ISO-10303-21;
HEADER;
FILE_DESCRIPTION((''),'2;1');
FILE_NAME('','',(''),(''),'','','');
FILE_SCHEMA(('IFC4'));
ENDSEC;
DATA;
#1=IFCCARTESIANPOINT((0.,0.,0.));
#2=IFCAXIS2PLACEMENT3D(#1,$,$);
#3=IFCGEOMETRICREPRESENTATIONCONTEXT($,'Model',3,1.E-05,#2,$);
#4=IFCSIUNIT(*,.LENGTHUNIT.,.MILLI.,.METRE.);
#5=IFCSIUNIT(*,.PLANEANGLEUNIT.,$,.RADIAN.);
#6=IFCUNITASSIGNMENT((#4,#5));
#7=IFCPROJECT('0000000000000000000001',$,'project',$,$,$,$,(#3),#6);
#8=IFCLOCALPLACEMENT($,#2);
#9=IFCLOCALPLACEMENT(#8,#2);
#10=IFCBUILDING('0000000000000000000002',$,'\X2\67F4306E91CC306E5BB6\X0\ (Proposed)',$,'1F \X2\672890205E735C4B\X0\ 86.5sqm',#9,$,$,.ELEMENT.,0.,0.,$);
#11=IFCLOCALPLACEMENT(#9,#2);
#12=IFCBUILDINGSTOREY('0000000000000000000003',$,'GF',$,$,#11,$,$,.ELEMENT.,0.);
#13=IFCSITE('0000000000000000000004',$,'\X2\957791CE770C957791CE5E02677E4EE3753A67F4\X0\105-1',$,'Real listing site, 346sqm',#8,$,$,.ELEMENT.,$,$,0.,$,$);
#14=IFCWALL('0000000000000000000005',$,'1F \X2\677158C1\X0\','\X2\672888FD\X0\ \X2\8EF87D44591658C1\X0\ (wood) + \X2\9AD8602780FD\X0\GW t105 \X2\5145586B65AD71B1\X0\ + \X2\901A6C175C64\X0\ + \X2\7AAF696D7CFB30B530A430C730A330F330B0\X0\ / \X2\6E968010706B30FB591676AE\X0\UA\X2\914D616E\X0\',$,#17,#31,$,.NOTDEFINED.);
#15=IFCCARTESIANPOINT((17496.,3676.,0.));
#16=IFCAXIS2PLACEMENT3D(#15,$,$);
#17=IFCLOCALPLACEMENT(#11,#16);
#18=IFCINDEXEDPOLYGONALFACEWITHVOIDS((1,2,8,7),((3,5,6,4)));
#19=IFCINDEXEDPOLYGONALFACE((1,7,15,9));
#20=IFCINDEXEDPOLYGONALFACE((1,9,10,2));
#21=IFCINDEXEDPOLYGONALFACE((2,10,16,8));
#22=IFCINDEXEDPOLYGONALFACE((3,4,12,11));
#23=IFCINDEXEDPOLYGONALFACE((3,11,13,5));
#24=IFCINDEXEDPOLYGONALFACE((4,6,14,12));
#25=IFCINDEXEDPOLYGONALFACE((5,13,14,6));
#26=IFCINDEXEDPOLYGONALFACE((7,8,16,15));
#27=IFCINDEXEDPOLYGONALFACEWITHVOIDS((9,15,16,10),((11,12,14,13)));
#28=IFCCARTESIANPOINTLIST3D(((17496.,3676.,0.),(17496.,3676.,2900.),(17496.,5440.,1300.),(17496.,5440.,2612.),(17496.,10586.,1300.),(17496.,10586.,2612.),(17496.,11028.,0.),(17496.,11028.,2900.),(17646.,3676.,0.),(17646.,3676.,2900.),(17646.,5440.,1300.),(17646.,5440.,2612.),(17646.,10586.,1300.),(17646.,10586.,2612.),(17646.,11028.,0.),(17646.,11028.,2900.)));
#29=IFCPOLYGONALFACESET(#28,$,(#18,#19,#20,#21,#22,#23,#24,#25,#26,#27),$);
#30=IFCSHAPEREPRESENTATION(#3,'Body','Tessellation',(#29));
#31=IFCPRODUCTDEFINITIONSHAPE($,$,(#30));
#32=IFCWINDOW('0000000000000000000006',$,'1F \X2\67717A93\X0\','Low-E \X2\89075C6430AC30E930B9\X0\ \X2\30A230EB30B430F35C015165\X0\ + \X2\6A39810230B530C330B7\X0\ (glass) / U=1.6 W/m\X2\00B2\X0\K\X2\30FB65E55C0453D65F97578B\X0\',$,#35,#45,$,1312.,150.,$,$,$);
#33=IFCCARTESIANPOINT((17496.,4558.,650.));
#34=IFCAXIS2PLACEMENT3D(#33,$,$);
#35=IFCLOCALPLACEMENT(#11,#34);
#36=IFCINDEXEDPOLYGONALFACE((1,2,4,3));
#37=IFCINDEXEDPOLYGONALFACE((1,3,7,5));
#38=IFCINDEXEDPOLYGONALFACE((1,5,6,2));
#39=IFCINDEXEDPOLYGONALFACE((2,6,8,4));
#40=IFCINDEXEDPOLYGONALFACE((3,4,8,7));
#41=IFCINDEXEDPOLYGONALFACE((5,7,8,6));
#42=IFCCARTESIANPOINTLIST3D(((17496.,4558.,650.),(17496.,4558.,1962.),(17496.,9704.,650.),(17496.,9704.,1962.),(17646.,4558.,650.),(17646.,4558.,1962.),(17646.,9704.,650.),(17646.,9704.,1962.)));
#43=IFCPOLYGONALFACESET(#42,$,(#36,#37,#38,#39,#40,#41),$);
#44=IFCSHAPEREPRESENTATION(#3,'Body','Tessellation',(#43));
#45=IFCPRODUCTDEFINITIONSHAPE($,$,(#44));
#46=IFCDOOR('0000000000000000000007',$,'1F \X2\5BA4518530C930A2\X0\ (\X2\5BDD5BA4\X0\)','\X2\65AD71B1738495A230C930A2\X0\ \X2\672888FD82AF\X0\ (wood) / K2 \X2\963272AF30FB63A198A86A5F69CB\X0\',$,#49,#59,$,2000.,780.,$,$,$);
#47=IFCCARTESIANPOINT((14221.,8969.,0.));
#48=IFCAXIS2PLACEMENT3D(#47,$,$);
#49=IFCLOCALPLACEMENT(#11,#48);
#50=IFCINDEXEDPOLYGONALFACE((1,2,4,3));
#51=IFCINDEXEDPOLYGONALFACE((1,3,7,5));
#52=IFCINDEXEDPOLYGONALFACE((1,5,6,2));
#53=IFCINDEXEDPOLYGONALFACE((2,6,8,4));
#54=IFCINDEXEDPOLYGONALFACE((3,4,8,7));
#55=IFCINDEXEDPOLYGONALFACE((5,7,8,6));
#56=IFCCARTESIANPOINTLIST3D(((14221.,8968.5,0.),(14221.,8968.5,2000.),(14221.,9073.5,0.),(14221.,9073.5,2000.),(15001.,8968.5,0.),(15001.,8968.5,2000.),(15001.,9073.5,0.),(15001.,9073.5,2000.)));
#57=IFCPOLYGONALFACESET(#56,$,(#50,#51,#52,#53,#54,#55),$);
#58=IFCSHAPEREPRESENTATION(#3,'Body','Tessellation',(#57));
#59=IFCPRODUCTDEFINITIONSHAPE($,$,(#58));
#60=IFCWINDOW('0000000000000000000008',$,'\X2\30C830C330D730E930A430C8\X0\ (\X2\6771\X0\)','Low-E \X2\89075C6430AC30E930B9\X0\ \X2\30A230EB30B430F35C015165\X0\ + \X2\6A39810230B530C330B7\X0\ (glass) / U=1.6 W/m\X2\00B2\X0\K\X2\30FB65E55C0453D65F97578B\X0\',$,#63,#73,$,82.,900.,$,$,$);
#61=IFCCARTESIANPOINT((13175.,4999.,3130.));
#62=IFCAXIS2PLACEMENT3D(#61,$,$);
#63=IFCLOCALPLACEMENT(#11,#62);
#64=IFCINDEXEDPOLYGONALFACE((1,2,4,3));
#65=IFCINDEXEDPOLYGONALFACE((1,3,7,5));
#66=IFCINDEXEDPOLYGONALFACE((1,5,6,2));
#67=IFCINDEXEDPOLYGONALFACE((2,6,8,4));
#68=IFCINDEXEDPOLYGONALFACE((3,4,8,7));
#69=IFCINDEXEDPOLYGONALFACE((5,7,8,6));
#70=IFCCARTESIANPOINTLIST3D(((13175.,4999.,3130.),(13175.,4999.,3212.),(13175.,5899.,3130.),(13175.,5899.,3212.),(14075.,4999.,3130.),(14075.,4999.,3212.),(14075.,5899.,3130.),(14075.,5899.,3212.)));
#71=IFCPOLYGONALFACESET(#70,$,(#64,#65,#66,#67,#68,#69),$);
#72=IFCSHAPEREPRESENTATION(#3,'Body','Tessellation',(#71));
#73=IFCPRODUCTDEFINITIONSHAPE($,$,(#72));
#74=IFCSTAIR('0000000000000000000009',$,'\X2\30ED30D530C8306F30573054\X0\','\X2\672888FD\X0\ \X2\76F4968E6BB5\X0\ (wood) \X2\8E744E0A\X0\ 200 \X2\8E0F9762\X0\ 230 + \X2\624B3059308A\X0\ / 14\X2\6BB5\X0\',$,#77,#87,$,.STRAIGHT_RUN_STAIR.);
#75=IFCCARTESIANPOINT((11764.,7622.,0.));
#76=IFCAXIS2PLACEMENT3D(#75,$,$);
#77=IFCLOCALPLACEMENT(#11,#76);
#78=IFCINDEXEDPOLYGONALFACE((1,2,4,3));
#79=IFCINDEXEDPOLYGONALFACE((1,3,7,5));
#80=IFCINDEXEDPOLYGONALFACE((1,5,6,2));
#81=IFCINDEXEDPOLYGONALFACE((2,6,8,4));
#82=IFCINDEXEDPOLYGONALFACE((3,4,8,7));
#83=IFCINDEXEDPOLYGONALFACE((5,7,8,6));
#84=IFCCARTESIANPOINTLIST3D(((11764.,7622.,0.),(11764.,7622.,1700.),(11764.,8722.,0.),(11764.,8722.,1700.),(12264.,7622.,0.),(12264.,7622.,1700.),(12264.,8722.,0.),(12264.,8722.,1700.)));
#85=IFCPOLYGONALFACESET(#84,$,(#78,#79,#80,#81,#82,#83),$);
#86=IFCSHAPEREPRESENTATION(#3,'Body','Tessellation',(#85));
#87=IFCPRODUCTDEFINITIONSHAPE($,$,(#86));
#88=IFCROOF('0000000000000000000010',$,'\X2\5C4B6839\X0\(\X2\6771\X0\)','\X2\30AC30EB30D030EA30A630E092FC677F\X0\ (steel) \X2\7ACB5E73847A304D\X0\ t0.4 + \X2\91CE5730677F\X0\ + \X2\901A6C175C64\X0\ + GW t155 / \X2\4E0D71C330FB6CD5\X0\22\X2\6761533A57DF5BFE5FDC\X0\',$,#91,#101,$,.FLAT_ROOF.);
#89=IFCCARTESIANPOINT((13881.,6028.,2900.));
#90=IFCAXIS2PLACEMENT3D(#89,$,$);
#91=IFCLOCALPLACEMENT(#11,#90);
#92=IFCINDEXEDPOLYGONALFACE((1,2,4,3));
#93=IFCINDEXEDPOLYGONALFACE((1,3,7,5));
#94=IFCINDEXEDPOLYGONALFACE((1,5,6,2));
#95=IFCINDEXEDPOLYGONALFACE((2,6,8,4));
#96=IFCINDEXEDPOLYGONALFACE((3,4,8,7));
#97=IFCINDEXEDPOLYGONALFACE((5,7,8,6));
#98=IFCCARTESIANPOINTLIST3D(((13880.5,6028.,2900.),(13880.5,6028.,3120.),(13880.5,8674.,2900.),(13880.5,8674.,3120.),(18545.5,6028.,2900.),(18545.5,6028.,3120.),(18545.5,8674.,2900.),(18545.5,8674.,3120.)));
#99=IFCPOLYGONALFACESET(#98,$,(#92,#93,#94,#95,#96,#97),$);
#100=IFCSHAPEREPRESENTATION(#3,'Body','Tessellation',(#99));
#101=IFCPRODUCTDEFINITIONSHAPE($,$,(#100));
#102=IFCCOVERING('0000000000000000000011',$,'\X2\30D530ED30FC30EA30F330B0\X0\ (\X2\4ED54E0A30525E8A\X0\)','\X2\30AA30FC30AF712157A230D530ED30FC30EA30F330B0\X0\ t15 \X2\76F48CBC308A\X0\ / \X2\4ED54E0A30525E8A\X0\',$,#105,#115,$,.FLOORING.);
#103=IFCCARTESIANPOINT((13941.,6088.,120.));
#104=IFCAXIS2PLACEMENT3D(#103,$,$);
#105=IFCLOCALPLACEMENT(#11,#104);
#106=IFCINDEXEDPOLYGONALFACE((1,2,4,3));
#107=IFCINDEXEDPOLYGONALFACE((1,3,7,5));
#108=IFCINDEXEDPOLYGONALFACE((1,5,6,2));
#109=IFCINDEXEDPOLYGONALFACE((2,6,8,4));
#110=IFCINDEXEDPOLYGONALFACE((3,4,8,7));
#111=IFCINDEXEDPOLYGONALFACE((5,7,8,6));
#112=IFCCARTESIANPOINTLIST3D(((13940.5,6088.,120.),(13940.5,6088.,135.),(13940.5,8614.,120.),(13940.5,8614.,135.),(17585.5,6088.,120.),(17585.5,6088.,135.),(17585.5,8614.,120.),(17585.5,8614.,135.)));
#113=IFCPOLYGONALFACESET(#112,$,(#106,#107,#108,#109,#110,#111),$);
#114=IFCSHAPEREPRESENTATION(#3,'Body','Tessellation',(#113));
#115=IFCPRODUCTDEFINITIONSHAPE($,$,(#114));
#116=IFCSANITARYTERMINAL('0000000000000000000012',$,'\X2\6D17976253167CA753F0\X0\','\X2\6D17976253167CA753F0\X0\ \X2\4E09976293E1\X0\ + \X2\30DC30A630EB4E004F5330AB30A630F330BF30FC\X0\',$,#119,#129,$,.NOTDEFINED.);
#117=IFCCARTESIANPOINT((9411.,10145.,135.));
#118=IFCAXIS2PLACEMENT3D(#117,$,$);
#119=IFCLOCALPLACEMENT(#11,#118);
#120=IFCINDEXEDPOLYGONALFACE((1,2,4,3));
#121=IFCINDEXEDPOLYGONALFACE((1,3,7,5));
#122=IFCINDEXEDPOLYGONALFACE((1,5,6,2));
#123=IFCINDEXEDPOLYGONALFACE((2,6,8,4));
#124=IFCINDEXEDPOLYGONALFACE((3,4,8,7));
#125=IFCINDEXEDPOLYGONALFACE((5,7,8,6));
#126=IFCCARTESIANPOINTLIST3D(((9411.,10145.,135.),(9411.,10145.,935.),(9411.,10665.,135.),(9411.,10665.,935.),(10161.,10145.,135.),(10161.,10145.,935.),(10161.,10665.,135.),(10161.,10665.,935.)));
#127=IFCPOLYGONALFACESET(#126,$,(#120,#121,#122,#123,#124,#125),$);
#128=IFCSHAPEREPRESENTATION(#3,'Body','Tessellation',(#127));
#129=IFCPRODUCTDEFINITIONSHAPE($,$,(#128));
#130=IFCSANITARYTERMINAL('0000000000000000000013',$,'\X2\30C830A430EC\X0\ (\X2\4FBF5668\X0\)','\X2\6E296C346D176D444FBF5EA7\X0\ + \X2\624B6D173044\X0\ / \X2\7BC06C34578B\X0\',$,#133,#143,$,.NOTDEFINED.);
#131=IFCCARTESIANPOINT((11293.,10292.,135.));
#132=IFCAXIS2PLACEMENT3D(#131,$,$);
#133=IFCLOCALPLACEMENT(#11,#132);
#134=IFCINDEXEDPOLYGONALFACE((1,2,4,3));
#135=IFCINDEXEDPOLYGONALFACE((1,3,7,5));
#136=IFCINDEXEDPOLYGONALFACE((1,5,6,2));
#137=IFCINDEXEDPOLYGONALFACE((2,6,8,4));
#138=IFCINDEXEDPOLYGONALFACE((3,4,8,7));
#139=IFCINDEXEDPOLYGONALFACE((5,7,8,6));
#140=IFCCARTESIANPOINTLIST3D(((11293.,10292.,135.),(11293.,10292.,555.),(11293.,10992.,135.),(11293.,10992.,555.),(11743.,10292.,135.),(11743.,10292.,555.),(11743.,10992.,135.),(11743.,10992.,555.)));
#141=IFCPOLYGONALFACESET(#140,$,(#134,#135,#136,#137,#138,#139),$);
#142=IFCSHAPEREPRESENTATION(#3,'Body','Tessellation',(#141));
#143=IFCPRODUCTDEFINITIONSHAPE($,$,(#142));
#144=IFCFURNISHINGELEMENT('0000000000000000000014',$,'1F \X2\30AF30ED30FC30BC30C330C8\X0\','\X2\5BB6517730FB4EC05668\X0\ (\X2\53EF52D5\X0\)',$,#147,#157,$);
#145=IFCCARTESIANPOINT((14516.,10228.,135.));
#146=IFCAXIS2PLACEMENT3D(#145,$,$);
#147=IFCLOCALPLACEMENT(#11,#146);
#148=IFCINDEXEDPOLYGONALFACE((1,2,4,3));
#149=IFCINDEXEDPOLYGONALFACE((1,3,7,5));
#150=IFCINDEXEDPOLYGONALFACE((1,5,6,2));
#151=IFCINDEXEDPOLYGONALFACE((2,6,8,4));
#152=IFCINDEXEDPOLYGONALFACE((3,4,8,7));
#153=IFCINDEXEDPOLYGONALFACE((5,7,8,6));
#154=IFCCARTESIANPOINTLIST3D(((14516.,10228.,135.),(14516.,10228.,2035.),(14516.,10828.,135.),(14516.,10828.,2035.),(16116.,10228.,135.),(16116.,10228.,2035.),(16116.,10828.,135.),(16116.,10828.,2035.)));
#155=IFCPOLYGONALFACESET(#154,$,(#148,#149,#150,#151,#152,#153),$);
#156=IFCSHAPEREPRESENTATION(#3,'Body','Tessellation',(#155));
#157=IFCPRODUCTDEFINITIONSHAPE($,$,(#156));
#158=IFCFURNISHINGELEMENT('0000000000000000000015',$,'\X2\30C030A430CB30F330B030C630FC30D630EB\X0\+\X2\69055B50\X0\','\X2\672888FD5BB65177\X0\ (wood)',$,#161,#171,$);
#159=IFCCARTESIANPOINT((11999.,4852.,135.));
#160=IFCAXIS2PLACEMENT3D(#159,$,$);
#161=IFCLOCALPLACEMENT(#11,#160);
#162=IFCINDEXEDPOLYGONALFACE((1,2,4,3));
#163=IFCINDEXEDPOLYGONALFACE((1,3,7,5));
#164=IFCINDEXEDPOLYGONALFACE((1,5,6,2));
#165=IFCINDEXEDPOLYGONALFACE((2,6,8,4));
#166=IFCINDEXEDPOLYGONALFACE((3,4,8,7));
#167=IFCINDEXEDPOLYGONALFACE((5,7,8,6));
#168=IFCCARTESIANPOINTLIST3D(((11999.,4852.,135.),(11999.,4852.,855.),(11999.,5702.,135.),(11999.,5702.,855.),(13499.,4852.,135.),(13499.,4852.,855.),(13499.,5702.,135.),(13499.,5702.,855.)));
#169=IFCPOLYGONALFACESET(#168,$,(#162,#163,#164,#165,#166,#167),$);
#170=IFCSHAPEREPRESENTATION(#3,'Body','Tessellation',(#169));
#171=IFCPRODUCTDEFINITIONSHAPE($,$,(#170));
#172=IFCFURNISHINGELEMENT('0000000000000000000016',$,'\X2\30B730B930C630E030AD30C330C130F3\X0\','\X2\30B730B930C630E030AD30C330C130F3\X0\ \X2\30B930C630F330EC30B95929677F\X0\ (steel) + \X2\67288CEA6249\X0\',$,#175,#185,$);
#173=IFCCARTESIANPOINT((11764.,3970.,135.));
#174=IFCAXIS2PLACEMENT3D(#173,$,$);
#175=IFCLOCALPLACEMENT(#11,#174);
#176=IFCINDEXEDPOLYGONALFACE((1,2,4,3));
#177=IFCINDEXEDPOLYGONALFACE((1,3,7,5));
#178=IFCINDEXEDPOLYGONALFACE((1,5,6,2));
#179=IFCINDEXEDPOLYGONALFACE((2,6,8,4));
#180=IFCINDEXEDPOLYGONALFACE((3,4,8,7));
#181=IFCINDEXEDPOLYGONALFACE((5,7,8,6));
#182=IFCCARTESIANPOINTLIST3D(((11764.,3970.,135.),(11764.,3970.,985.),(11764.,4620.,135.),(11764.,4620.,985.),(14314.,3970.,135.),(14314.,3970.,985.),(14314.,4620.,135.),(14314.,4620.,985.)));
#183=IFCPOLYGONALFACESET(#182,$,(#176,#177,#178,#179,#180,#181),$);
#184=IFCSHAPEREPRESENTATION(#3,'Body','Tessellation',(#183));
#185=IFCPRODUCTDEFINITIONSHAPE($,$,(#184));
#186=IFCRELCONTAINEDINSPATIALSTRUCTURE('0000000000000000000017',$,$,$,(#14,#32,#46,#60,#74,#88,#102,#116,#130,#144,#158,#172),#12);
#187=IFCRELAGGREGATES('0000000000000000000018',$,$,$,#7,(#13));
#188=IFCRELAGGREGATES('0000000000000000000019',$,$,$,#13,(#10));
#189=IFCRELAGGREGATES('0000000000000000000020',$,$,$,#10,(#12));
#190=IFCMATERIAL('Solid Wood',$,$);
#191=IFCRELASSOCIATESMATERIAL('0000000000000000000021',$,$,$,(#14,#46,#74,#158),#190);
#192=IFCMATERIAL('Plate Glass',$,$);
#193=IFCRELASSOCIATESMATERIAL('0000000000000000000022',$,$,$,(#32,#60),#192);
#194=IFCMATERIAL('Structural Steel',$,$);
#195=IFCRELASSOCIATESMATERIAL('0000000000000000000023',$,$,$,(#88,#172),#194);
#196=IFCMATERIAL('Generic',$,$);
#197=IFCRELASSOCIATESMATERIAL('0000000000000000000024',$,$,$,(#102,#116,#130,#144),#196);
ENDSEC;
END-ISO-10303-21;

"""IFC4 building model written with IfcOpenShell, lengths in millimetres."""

from ifc_helpers import new_model, si_unit, frame, frame_2d, origin, place, context, project, spatial, rectangle, extrude, material, element, fill, save


model = new_model("IFC4")

# Units and contexts
model_context = context("Model", 3, precision=1e-05, world=origin())
ifc_project = project(units=[si_unit("LENGTHUNIT", "METRE", prefix="MILLI"), si_unit("PLANEANGLEUNIT", "RADIAN")], contexts=[model_context])

# Site, building, storey
site_placement = place(None, origin())
site = spatial("IfcSite", under=ifc_project, at=site_placement, Name="長野県長野市松代町柴105-1", ObjectType="Real listing site, 346sqm", CompositionType="ELEMENT", RefElevation=0.0)
building_placement = place(site_placement, origin())
building = spatial("IfcBuilding", under=site, at=building_placement, Name="柴の里の家 (Proposed)", ObjectType="1F 木造平屋 86.5sqm", CompositionType="ELEMENT", ElevationOfRefHeight=0.0, ElevationOfTerrain=0.0)
storey_placement = place(building_placement, origin())
storey = spatial("IfcBuildingStorey", under=building, at=storey_placement, Name="GF", CompositionType="ELEMENT", Elevation=0.0)

# Shared definitions
ifc_material_1 = material(Name="Solid Wood")

# Wall, opening, window
wall_1_placement = place(storey_placement, frame((17496.0, 3676.0, 0.0)))
wall_1 = element("IfcWall", 1, at=wall_1_placement, inside=storey, material=ifc_material_1, Name="1F 東壁", Description="木製 軸組外壁 (wood) + 高性能GW t105 充填断熱 + 通気層 + 窯業系サイディング / 準耐火・外皮UA配慮", PredefinedType="NOTDEFINED", context=model_context, shape_type="SweptSolid", body=[
    extrude(rectangle(XDim=150.0, YDim=7352.0, at=frame_2d((75.0, 3676.0))), frame((17496.0, 3676.0, 0.0)), (0.0, 0.0, 1.0), 2900.0),
])
opening_1_placement = place(storey_placement, frame((17496.0, 4558.0, 650.0)))
opening_1 = element("IfcOpeningElement", 2, at=opening_1_placement, cuts=wall_1, PredefinedType="NOTDEFINED", context=model_context, shape_type="SweptSolid", body=[
    extrude(rectangle(XDim=150.0, YDim=5146.0, at=frame_2d((75.0, 2573.0))), frame((17496.0, 4558.0, 650.0)), (0.0, 0.0, 1.0), 1312.0),
])
ifc_material_2 = material(Name="Plate Glass")
window_1_placement = place(storey_placement, frame((17496.0, 4558.0, 650.0)))
window_1 = element("IfcWindow", 3, at=window_1_placement, inside=storey, material=ifc_material_2, Name="1F 東窓", Description="Low-E 複層ガラス アルゴン封入 + 樹脂サッシ (glass) / U=1.6 W/m²K・日射取得型", OverallHeight=1312.0, OverallWidth=150.0, context=model_context, shape_type="SweptSolid", body=[
    extrude(rectangle(XDim=150.0, YDim=5146.0, at=frame_2d((75.0, 2573.0))), frame((17496.0, 4558.0, 650.0)), (0.0, 0.0, 1.0), 1312.0),
])
fill(opening_1, window_1)

# Door
door_placement = place(storey_placement, frame((14221.0, 8969.0, 0.0)))
element("IfcDoor", 4, at=door_placement, inside=storey, material=ifc_material_1, Name="1F 室内ドア (寝室)", Description="断熱玄関ドア 木製芯 (wood) / K2 防犯・採風機構", OverallHeight=2000.0, OverallWidth=780.0, context=model_context, shape_type="SweptSolid", body=[
    extrude(rectangle(XDim=780.0, YDim=105.0, at=frame_2d((390.0, 52.0))), frame((14221.0, 8969.0, 0.0)), (0.0, 0.0, 1.0), 2000.0),
])

# Window
window_2_placement = place(storey_placement, frame((13175.0, 4999.0, 3130.0)))
element("IfcWindow", 5, at=window_2_placement, inside=storey, material=ifc_material_2, Name="トップライト (東)", Description="Low-E 複層ガラス アルゴン封入 + 樹脂サッシ (glass) / U=1.6 W/m²K・日射取得型", OverallHeight=82.0, OverallWidth=900.0, context=model_context, shape_type="SweptSolid", body=[
    extrude(rectangle(XDim=900.0, YDim=900.0, at=frame_2d((450.0, 450.0))), frame((13175.0, 4999.0, 3130.0)), (0.0, 0.0, 1.0), 82.0),
])

# Stair
stair_placement = place(storey_placement, frame((11764.0, 7622.0, 0.0)))
element("IfcStair", 6, at=stair_placement, inside=storey, material=ifc_material_1, Name="ロフトはしご", Description="木製 直階段 (wood) 蹴上 200 踏面 230 + 手すり / 14段", PredefinedType="STRAIGHT_RUN_STAIR", context=model_context, shape_type="SweptSolid", body=[
    extrude(rectangle(XDim=500.0, YDim=1100.0, at=frame_2d((250.0, 550.0))), frame((11764.0, 7622.0, 0.0)), (0.0, 0.0, 1.0), 1700.0),
])

# Roof
ifc_material_3 = material(Name="Structural Steel")
roof_placement = place(storey_placement, frame((13881.0, 6028.0, 2900.0)))
element("IfcRoof", 7, at=roof_placement, inside=storey, material=ifc_material_3, Name="屋根(東)", Description="ガルバリウム鋼板 (steel) 立平葺き t0.4 + 野地板 + 通気層 + GW t155 / 不燃・法22条区域対応", PredefinedType="FLAT_ROOF", context=model_context, shape_type="SweptSolid", body=[
    extrude(rectangle(XDim=4665.0, YDim=2646.0, at=frame_2d((2332.0, 1323.0))), frame((13881.0, 6028.0, 2900.0)), (0.0, 0.0, 1.0), 220.0),
])

# Covering
ifc_material_4 = material(Name="Generic")
covering_placement = place(storey_placement, frame((13941.0, 6088.0, 120.0)))
element("IfcCovering", 8, at=covering_placement, inside=storey, material=ifc_material_4, Name="フローリング (仕上げ床)", Description="オーク無垢フローリング t15 直貼り / 仕上げ床", PredefinedType="FLOORING", context=model_context, shape_type="SweptSolid", body=[
    extrude(rectangle(XDim=3645.0, YDim=2526.0, at=frame_2d((1822.0, 1263.0))), frame((13941.0, 6088.0, 120.0)), (0.0, 0.0, 1.0), 15.0),
])

# Sanitary terminals
sanitary_terminal_1_placement = place(storey_placement, frame((9411.0, 10145.0, 135.0)))
element("IfcSanitaryTerminal", 9, at=sanitary_terminal_1_placement, inside=storey, material=ifc_material_4, Name="洗面化粧台", Description="洗面化粧台 三面鏡 + ボウル一体カウンター", PredefinedType="NOTDEFINED", context=model_context, shape_type="SweptSolid", body=[
    extrude(rectangle(XDim=750.0, YDim=520.0, at=frame_2d((375.0, 260.0))), frame((9411.0, 10145.0, 135.0)), (0.0, 0.0, 1.0), 800.0),
])
sanitary_terminal_2_placement = place(storey_placement, frame((11293.0, 10292.0, 135.0)))
element("IfcSanitaryTerminal", 10, at=sanitary_terminal_2_placement, inside=storey, material=ifc_material_4, Name="トイレ (便器)", Description="温水洗浄便座 + 手洗い / 節水型", PredefinedType="NOTDEFINED", context=model_context, shape_type="SweptSolid", body=[
    extrude(rectangle(XDim=450.0, YDim=700.0, at=frame_2d((225.0, 350.0))), frame((11293.0, 10292.0, 135.0)), (0.0, 0.0, 1.0), 420.0),
])

# Furnishing elements
furnishing_1_placement = place(storey_placement, frame((14516.0, 10228.0, 135.0)))
element("IfcFurnishingElement", 11, at=furnishing_1_placement, inside=storey, material=ifc_material_4, Name="1F クローゼット", Description="家具・什器 (可動)", context=model_context, shape_type="SweptSolid", body=[
    extrude(rectangle(XDim=1600.0, YDim=600.0, at=frame_2d((800.0, 300.0))), frame((14516.0, 10228.0, 135.0)), (0.0, 0.0, 1.0), 1900.0),
])
furnishing_2_placement = place(storey_placement, frame((11999.0, 4852.0, 135.0)))
element("IfcFurnishingElement", 12, at=furnishing_2_placement, inside=storey, material=ifc_material_1, Name="ダイニングテーブル+椅子", Description="木製家具 (wood)", context=model_context, shape_type="SweptSolid", body=[
    extrude(rectangle(XDim=1500.0, YDim=850.0, at=frame_2d((750.0, 425.0))), frame((11999.0, 4852.0, 135.0)), (0.0, 0.0, 1.0), 720.0),
])
furnishing_3_placement = place(storey_placement, frame((11764.0, 3970.0, 135.0)))
element("IfcFurnishingElement", 13, at=furnishing_3_placement, inside=storey, material=ifc_material_3, Name="システムキッチン", Description="システムキッチン ステンレス天板 (steel) + 木質扉", context=model_context, shape_type="SweptSolid", body=[
    extrude(rectangle(XDim=2550.0, YDim=650.0, at=frame_2d((1275.0, 325.0))), frame((11764.0, 3970.0, 135.0)), (0.0, 0.0, 1.0), 850.0),
])

save(model, "model.ifc")
